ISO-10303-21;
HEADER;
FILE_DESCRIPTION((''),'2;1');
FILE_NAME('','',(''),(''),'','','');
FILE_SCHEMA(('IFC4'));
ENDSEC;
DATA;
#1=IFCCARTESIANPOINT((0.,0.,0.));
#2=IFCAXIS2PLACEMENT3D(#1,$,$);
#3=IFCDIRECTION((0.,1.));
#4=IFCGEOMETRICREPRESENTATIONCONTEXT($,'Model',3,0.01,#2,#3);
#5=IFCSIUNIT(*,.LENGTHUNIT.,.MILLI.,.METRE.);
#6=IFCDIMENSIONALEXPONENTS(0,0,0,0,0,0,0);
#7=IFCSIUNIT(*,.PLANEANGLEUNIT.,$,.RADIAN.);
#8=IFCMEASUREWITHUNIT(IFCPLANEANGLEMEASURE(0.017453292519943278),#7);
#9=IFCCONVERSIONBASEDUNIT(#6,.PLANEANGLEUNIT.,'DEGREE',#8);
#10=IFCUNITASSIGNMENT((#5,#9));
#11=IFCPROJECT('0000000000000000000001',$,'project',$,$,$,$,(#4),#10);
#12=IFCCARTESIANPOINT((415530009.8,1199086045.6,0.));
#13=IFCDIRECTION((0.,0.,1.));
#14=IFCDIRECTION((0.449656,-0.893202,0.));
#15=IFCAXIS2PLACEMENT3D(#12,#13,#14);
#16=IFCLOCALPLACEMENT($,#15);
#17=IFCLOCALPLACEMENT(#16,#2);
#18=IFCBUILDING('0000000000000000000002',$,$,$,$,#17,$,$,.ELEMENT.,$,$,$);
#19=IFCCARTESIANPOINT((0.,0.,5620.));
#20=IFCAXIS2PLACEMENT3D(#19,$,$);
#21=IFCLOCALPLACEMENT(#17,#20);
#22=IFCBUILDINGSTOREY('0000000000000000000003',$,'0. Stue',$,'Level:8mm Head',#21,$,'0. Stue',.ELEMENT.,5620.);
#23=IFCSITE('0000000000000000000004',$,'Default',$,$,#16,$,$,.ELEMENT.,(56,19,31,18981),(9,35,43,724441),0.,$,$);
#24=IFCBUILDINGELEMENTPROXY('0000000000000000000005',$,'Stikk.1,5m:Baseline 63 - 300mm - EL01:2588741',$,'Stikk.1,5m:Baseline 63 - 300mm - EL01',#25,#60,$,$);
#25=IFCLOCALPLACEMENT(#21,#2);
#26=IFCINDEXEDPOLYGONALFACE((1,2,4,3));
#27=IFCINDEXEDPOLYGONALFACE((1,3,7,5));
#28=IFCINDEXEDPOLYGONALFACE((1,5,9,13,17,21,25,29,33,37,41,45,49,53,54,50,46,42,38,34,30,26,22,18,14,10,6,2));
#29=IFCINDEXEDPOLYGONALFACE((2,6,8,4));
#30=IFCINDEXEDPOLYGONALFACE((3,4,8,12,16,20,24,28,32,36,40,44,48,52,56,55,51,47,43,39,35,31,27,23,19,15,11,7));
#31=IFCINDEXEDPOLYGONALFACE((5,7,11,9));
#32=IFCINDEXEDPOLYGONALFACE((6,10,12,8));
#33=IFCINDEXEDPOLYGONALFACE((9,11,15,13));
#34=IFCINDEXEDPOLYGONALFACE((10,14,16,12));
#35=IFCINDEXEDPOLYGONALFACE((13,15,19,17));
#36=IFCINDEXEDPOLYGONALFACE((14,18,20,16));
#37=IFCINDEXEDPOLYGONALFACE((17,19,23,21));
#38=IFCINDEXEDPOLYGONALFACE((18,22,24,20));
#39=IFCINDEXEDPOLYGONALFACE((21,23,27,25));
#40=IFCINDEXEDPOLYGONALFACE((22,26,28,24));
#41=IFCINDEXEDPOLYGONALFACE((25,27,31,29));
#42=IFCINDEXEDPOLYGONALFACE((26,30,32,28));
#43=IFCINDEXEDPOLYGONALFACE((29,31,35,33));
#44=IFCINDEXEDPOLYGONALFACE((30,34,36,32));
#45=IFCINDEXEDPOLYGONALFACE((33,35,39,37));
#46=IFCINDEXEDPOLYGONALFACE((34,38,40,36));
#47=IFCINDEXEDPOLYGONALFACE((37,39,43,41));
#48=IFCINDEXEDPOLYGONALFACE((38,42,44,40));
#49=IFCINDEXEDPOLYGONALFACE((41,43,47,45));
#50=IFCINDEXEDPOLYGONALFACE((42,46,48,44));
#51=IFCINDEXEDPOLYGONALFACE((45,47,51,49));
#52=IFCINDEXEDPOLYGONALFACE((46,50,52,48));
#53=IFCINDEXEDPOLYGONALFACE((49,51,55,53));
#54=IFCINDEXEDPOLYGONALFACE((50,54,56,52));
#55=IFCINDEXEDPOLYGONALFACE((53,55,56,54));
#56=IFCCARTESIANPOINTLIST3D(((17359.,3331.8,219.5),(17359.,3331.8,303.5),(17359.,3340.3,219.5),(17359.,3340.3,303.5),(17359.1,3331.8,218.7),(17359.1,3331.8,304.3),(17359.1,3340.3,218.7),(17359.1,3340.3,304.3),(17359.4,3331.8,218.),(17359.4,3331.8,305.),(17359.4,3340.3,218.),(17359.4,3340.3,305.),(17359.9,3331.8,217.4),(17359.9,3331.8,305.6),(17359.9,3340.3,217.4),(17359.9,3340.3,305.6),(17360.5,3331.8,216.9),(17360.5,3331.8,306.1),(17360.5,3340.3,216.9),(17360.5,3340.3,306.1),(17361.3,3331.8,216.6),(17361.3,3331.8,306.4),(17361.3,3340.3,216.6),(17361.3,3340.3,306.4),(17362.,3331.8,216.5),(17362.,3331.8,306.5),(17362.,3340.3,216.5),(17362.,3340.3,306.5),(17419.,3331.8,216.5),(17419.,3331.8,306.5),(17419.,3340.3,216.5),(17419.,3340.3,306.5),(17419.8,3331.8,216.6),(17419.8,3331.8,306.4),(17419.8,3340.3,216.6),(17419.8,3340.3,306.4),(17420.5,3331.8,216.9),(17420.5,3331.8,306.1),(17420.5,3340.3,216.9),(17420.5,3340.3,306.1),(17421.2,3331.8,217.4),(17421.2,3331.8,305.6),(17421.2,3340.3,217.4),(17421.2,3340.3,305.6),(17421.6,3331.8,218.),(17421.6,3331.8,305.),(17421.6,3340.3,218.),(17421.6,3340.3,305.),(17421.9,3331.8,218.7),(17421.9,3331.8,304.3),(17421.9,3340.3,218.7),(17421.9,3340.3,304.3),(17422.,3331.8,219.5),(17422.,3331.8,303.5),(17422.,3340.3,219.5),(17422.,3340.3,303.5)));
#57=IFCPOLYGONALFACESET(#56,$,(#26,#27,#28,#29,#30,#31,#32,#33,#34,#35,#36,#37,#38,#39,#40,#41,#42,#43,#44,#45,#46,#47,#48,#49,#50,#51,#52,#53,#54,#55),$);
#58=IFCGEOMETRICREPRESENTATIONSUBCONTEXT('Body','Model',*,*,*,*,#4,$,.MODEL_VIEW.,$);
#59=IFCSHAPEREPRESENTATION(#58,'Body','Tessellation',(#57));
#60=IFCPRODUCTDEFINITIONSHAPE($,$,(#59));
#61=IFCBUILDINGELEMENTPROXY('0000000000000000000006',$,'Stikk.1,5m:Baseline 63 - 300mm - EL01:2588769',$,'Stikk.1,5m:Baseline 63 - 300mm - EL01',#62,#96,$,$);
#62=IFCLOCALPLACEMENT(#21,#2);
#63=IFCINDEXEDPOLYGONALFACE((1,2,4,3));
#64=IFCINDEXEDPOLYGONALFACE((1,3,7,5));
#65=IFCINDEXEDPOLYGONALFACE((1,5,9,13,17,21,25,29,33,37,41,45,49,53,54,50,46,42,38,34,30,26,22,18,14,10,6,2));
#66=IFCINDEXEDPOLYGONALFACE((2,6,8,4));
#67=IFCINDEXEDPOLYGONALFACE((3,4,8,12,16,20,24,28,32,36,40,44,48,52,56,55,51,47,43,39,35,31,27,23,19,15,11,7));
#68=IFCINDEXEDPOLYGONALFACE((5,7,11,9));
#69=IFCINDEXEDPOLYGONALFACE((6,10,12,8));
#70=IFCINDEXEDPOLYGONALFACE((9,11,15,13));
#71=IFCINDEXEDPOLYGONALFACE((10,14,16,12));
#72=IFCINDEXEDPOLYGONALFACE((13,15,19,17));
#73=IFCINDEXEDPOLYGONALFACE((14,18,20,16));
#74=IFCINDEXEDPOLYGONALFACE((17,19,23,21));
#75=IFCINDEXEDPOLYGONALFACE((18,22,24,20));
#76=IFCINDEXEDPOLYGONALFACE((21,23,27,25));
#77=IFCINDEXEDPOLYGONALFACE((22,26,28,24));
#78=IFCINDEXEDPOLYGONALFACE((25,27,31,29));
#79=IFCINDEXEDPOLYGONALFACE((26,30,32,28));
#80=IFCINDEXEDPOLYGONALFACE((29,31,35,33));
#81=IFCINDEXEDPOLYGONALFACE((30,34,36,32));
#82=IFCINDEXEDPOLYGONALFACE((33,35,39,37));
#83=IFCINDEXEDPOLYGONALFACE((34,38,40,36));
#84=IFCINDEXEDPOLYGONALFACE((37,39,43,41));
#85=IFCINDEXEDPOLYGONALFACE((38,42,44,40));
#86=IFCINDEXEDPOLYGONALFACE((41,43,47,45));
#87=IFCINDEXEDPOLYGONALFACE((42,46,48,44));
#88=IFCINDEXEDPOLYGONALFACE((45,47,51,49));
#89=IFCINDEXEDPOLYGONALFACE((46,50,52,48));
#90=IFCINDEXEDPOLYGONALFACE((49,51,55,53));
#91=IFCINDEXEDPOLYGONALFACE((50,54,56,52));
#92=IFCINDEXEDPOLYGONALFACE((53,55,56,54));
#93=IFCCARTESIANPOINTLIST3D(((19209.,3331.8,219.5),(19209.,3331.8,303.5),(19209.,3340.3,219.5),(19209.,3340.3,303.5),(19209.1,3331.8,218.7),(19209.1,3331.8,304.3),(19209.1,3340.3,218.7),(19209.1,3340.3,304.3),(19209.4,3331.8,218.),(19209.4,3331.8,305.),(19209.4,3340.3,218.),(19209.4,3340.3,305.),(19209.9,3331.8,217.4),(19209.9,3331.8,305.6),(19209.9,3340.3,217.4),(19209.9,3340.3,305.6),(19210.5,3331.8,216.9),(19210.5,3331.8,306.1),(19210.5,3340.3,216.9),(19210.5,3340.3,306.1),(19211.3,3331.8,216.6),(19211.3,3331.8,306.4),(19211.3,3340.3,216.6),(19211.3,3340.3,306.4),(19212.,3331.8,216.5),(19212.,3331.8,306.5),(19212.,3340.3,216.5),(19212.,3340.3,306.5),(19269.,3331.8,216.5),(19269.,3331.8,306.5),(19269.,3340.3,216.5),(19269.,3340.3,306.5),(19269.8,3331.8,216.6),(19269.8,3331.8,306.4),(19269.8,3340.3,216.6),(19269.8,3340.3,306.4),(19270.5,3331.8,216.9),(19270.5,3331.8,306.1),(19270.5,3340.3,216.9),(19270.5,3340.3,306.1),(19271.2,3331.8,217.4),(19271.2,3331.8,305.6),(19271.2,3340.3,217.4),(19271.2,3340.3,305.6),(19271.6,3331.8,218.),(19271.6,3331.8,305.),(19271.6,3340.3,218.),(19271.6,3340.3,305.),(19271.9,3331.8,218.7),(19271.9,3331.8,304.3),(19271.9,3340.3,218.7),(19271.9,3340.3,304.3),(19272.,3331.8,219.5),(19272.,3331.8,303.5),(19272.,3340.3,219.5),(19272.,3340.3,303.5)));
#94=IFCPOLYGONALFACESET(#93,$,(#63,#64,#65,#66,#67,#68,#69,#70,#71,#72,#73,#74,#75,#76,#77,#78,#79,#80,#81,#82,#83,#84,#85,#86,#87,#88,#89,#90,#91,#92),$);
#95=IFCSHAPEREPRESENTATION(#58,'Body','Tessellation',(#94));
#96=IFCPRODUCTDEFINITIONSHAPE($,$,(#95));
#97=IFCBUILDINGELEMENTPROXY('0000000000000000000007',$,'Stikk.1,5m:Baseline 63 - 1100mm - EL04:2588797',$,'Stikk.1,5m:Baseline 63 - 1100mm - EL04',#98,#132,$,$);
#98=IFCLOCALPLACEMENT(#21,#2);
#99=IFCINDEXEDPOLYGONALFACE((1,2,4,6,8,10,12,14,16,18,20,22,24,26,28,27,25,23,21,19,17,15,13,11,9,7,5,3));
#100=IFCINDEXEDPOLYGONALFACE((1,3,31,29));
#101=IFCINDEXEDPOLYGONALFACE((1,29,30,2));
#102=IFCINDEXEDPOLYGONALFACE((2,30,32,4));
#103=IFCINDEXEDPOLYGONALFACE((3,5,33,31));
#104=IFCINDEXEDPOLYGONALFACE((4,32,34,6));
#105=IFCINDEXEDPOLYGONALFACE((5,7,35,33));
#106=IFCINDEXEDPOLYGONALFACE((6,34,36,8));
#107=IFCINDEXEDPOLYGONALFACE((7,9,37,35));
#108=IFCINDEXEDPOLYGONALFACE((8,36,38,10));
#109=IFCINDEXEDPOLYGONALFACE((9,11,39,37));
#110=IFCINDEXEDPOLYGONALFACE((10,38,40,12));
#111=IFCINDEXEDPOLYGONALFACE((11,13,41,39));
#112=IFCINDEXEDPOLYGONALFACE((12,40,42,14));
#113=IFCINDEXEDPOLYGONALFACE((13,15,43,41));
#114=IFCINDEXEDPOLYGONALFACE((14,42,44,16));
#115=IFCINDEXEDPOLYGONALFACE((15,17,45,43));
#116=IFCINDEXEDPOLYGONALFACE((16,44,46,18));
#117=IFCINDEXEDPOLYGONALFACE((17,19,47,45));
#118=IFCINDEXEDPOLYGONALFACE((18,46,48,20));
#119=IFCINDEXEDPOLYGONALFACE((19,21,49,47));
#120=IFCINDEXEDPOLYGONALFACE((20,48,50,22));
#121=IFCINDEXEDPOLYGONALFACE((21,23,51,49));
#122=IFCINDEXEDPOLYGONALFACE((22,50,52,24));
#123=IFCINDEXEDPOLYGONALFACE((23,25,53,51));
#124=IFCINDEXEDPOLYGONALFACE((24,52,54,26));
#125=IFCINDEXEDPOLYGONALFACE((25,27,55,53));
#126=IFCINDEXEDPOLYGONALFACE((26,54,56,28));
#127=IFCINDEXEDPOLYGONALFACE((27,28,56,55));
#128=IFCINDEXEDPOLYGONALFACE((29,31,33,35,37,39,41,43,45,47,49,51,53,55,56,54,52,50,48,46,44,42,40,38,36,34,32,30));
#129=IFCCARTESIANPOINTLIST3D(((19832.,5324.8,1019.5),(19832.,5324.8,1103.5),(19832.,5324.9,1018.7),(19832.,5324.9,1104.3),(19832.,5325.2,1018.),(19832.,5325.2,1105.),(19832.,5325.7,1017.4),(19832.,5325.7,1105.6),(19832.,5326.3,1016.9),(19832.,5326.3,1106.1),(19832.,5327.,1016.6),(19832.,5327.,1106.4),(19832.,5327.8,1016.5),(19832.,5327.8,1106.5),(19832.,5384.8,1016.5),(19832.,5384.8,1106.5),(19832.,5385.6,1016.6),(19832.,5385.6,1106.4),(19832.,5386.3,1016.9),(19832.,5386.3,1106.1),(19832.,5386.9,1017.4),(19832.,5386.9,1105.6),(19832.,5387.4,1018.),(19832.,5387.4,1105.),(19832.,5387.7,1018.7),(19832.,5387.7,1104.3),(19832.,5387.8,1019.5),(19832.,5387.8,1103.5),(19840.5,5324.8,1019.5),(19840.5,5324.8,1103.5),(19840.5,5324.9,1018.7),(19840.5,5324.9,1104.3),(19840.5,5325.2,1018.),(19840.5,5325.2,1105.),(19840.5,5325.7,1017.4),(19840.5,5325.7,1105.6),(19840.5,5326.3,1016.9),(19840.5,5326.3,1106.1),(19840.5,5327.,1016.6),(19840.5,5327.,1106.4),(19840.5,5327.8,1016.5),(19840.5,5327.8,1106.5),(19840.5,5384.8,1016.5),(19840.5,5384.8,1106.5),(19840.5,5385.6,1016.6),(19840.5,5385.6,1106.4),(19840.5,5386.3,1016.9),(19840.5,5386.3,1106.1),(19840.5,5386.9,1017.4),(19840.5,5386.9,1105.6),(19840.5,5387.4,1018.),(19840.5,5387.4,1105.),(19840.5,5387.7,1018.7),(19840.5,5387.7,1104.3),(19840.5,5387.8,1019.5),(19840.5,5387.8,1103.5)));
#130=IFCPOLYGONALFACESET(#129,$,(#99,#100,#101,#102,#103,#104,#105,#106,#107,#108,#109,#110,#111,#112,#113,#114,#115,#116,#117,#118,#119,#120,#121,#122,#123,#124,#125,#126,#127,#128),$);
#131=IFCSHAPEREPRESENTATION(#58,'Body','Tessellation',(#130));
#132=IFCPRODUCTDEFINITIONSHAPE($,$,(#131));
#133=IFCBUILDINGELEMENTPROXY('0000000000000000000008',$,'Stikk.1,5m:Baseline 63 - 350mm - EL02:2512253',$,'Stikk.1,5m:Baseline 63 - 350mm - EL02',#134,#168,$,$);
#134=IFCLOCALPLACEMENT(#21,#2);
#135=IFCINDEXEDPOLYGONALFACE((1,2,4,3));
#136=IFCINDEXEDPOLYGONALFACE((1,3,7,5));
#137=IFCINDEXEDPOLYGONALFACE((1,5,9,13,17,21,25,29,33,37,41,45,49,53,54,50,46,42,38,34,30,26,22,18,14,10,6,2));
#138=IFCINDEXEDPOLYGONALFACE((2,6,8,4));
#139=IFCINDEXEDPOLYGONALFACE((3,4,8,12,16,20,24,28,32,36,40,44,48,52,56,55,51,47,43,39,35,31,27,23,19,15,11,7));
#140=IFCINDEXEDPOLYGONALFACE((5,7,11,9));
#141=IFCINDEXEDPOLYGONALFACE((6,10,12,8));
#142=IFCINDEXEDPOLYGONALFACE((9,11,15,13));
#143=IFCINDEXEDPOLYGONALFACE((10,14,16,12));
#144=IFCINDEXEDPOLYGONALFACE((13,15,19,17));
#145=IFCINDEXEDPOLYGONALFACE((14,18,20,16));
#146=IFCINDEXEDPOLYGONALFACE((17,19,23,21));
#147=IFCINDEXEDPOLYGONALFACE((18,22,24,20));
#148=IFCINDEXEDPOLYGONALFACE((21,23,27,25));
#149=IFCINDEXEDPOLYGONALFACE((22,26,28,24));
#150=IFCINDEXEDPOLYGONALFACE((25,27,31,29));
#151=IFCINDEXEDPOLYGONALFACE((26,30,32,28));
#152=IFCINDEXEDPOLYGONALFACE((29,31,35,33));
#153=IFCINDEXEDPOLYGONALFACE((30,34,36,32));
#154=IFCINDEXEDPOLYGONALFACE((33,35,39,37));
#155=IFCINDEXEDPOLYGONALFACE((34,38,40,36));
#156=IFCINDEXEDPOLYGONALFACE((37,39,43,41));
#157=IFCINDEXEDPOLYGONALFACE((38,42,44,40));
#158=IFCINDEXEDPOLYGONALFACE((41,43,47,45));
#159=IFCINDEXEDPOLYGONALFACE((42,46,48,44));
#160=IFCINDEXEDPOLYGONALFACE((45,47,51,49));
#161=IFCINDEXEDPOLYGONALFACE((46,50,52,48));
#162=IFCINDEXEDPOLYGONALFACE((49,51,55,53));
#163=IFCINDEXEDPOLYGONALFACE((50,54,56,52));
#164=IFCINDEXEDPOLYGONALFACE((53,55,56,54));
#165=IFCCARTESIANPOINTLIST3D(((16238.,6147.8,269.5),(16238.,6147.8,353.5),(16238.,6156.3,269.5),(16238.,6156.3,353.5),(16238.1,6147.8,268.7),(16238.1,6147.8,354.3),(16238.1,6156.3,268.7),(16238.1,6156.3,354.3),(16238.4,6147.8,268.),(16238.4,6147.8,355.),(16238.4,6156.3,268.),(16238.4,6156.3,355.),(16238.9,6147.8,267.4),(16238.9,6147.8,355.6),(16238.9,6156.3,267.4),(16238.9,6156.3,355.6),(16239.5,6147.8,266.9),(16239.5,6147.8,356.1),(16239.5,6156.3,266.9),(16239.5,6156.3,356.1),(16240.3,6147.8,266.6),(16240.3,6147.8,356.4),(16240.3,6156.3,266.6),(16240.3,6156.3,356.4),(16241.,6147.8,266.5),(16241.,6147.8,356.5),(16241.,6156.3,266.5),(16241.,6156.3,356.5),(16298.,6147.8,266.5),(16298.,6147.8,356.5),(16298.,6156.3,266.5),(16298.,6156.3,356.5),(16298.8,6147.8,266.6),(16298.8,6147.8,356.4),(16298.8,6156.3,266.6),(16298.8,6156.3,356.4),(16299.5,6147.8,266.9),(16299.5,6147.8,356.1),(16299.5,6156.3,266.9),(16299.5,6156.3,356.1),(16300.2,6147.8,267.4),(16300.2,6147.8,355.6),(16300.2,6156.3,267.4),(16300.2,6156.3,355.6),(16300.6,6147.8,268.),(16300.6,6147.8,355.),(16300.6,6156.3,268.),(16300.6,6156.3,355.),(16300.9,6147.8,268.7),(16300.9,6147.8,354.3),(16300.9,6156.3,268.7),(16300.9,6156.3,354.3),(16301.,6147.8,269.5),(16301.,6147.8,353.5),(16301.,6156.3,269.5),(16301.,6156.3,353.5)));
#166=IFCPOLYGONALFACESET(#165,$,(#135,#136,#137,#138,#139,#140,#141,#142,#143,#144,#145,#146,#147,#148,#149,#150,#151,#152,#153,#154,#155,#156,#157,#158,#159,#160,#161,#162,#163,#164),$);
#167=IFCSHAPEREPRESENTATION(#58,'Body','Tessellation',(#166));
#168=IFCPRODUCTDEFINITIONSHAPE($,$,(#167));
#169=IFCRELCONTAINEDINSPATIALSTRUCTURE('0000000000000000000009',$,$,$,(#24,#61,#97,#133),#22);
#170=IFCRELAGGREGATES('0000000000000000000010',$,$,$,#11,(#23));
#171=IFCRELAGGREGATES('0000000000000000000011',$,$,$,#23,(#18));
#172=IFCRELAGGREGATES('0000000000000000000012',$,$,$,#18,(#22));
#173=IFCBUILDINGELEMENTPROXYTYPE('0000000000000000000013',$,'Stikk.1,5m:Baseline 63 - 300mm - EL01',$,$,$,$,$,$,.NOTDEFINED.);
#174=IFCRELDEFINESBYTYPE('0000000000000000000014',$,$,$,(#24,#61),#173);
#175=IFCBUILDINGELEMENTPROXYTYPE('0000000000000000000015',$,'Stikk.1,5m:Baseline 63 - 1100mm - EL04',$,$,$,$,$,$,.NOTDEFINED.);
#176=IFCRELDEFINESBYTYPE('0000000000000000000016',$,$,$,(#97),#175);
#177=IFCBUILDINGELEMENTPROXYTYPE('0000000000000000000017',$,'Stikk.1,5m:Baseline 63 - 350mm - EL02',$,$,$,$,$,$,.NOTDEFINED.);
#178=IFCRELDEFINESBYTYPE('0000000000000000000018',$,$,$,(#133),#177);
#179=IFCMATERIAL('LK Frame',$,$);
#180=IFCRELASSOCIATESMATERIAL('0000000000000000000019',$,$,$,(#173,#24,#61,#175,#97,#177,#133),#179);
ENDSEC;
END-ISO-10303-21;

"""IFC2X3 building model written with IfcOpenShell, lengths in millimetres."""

from ifc_helpers import new_model, entity, si_unit, converted_unit, direction, frame, frame_2d, origin, place, context, subcontext, project, spatial, polyline, circle_curve, parameter, trimmed, segment, composite_curve, outline, extrude, source, transform, mapped, material, type_object, type_shapes, element, save


model = new_model("IFC2X3")

# Units and contexts
model_context = context("Model", 3, precision=0.01, world=origin(), true_north=direction((0.0, 1.0)))
body_context = subcontext(model_context, "Body", "Model", "MODEL_VIEW")
ifc_project = project(units=[si_unit("LENGTHUNIT", "METRE", prefix="MILLI"), converted_unit("PLANEANGLEUNIT", "DEGREE", entity("IfcPlaneAngleMeasure", 0.017453292519943278), si_unit("PLANEANGLEUNIT", "RADIAN"), dimensions=[0, 0, 0, 0, 0, 0, 0])], contexts=[model_context])

# Site, building, storey
site_placement = place(None, frame((415530009.8, 1199086045.6, 0.0), z_axis=(0.0, 0.0, 1.0), x_axis=(0.449656, -0.893202, 0.0)))
site = spatial("IfcSite", under=ifc_project, at=site_placement, Name="Default", CompositionType="ELEMENT", RefLatitude=(56, 19, 31, 18981), RefLongitude=(9, 35, 43, 724441), RefElevation=0.0)
building_placement = place(site_placement, origin())
building = spatial("IfcBuilding", under=site, at=building_placement, CompositionType="ELEMENT")
storey_placement = place(building_placement, frame((0.0, 0.0, 5620.0)))
storey = spatial("IfcBuildingStorey", under=building, at=storey_placement, Name="0. Stue", ObjectType="Level:8mm Head", LongName="0. Stue", CompositionType="ELEMENT", Elevation=5620.0)

# Building element proxies
ifc_material_1 = material(Name="LK Frame")
building_element_proxy_type_1 = type_object("IfcBuildingElementProxyType", Name="Stikk.1,5m:Baseline 63 - 300mm - EL01", PredefinedType="NOTDEFINED", material=ifc_material_1)
shared_shape_1 = source(origin(), body_context, "Body", "SweptSolid", [
    extrude(outline(composite_curve([segment(polyline([(-42.0, -31.5), (42.0, -31.5)]), True, "CONTINUOUS"), segment(trimmed(circle_curve(frame_2d((42.0, -28.5), x_axis=(-1.0, 0.0)), 3.0), [parameter(90.0)], [parameter(180.0)], True, "PARAMETER"), True, "CONTINUOUS"), segment(polyline([(45.0, -28.5), (45.0, 28.5)]), True, "CONTINUOUS"), segment(trimmed(circle_curve(frame_2d((42.0, 28.5), x_axis=(-1.0, 0.0)), 3.0), [parameter(180.0)], [parameter(270.0)], True, "PARAMETER"), True, "CONTINUOUS"), segment(polyline([(42.0, 31.5), (-42.0, 31.5)]), True, "CONTINUOUS"), segment(trimmed(circle_curve(frame_2d((-42.0, 28.5), x_axis=(1.0, 0.0)), 3.0), [parameter(90.0)], [parameter(180.0)], True, "PARAMETER"), True, "CONTINUOUS"), segment(polyline([(-45.0, 28.5), (-45.0, -28.5)]), True, "CONTINUOUS"), segment(trimmed(circle_curve(frame_2d((-42.0, -28.5), x_axis=(1.0, 0.0)), 3.0), [parameter(180.0)], [parameter(270.0)], True, "PARAMETER"), True, "CONTINUOUS")], self_intersect=False)), frame((0.0, -38.5, 0.0), z_axis=(0.0, 0.0, 1.0), x_axis=(0.0, 1.0, 0.0)), (0.0, 0.0, 1.0), 8.5),
])
type_shapes(building_element_proxy_type_1, [shared_shape_1])
for number, where, z_axis, x_axis, name in (
    (1, (17390.5, 3331.8, 300.0), (0.0, 1.0, 0.0), (-1.0, 0.0, 0.0), "Stikk.1,5m:Baseline 63 - 300mm - EL01:2588741"),
    (2, (19240.5, 3331.8, 300.0), (0.0, 1.0, 0.0), (-1.0, 0.0, 0.0), "Stikk.1,5m:Baseline 63 - 300mm - EL01:2588769"),
):
    element("IfcBuildingElementProxy", number, at=place(storey_placement, frame(where, z_axis=z_axis, x_axis=x_axis)), inside=storey, type_object=building_element_proxy_type_1, material=ifc_material_1, Name=name, ObjectType="Stikk.1,5m:Baseline 63 - 300mm - EL01", context=body_context, shape_type="MappedRepresentation", body=[
        mapped(shared_shape_1, transform((0.0, 0.0, 0.0), scale=1.0)),
    ])
building_element_proxy_type_2 = type_object("IfcBuildingElementProxyType", Name="Stikk.1,5m:Baseline 63 - 1100mm - EL04", PredefinedType="NOTDEFINED", material=ifc_material_1)
shared_shape_2 = source(origin(), body_context, "Body", "SweptSolid", [
    extrude(outline(composite_curve([segment(polyline([(-42.0, -31.5), (42.0, -31.5)]), True, "CONTINUOUS"), segment(trimmed(circle_curve(frame_2d((42.0, -28.5), x_axis=(-1.0, 0.0)), 3.0), [parameter(90.0)], [parameter(180.0)], True, "PARAMETER"), True, "CONTINUOUS"), segment(polyline([(45.0, -28.5), (45.0, 28.5)]), True, "CONTINUOUS"), segment(trimmed(circle_curve(frame_2d((42.0, 28.5), x_axis=(-1.0, 0.0)), 3.0), [parameter(180.0)], [parameter(270.0)], True, "PARAMETER"), True, "CONTINUOUS"), segment(polyline([(42.0, 31.5), (-42.0, 31.5)]), True, "CONTINUOUS"), segment(trimmed(circle_curve(frame_2d((-42.0, 28.5), x_axis=(1.0, 0.0)), 3.0), [parameter(90.0)], [parameter(180.0)], True, "PARAMETER"), True, "CONTINUOUS"), segment(polyline([(-45.0, 28.5), (-45.0, -28.5)]), True, "CONTINUOUS"), segment(trimmed(circle_curve(frame_2d((-42.0, -28.5), x_axis=(1.0, 0.0)), 3.0), [parameter(180.0)], [parameter(270.0)], True, "PARAMETER"), True, "CONTINUOUS")], self_intersect=False)), frame((0.0, -38.5, 0.0), z_axis=(0.0, 0.0, 1.0), x_axis=(0.0, 1.0, 0.0)), (0.0, 0.0, 1.0), 8.5),
])
type_shapes(building_element_proxy_type_2, [shared_shape_2])
proxy_1_placement = place(storey_placement, frame((19840.5, 5356.3, 1100.0), z_axis=(-1.0, 0.0, 0.0), x_axis=(0.0, -1.0, 0.0)))
element("IfcBuildingElementProxy", 3, at=proxy_1_placement, inside=storey, type_object=building_element_proxy_type_2, material=ifc_material_1, Name="Stikk.1,5m:Baseline 63 - 1100mm - EL04:2588797", ObjectType="Stikk.1,5m:Baseline 63 - 1100mm - EL04", context=body_context, shape_type="MappedRepresentation", body=[
    mapped(shared_shape_2, transform((0.0, 0.0, 0.0), scale=1.0)),
])
building_element_proxy_type_3 = type_object("IfcBuildingElementProxyType", Name="Stikk.1,5m:Baseline 63 - 350mm - EL02", PredefinedType="NOTDEFINED", material=ifc_material_1)
shared_shape_3 = source(origin(), body_context, "Body", "SweptSolid", [
    extrude(outline(composite_curve([segment(polyline([(-42.0, -31.5), (42.0, -31.5)]), True, "CONTINUOUS"), segment(trimmed(circle_curve(frame_2d((42.0, -28.5), x_axis=(-1.0, 0.0)), 3.0), [parameter(90.0)], [parameter(180.0)], True, "PARAMETER"), True, "CONTINUOUS"), segment(polyline([(45.0, -28.5), (45.0, 28.5)]), True, "CONTINUOUS"), segment(trimmed(circle_curve(frame_2d((42.0, 28.5), x_axis=(-1.0, 0.0)), 3.0), [parameter(180.0)], [parameter(270.0)], True, "PARAMETER"), True, "CONTINUOUS"), segment(polyline([(42.0, 31.5), (-42.0, 31.5)]), True, "CONTINUOUS"), segment(trimmed(circle_curve(frame_2d((-42.0, 28.5), x_axis=(1.0, 0.0)), 3.0), [parameter(90.0)], [parameter(180.0)], True, "PARAMETER"), True, "CONTINUOUS"), segment(polyline([(-45.0, 28.5), (-45.0, -28.5)]), True, "CONTINUOUS"), segment(trimmed(circle_curve(frame_2d((-42.0, -28.5), x_axis=(1.0, 0.0)), 3.0), [parameter(180.0)], [parameter(270.0)], True, "PARAMETER"), True, "CONTINUOUS")], self_intersect=False)), frame((0.0, -38.5, 0.0), z_axis=(0.0, 0.0, 1.0), x_axis=(0.0, 1.0, 0.0)), (0.0, 0.0, 1.0), 8.5),
])
type_shapes(building_element_proxy_type_3, [shared_shape_3])
for number, where, z_axis, x_axis, name in (
    (4, (16269.5, 6156.3, 350.0), (0.0, -1.0, 0.0), (1.0, 0.0, 0.0), "Stikk.1,5m:Baseline 63 - 350mm - EL02:2512253"),
):
    element("IfcBuildingElementProxy", number, at=place(storey_placement, frame(where, z_axis=z_axis, x_axis=x_axis)), inside=storey, type_object=building_element_proxy_type_3, material=ifc_material_1, Name=name, ObjectType="Stikk.1,5m:Baseline 63 - 350mm - EL02", context=body_context, shape_type="MappedRepresentation", body=[
        mapped(shared_shape_3, transform((0.0, 0.0, 0.0), scale=1.0)),
    ])

save(model, "model.ifc")
